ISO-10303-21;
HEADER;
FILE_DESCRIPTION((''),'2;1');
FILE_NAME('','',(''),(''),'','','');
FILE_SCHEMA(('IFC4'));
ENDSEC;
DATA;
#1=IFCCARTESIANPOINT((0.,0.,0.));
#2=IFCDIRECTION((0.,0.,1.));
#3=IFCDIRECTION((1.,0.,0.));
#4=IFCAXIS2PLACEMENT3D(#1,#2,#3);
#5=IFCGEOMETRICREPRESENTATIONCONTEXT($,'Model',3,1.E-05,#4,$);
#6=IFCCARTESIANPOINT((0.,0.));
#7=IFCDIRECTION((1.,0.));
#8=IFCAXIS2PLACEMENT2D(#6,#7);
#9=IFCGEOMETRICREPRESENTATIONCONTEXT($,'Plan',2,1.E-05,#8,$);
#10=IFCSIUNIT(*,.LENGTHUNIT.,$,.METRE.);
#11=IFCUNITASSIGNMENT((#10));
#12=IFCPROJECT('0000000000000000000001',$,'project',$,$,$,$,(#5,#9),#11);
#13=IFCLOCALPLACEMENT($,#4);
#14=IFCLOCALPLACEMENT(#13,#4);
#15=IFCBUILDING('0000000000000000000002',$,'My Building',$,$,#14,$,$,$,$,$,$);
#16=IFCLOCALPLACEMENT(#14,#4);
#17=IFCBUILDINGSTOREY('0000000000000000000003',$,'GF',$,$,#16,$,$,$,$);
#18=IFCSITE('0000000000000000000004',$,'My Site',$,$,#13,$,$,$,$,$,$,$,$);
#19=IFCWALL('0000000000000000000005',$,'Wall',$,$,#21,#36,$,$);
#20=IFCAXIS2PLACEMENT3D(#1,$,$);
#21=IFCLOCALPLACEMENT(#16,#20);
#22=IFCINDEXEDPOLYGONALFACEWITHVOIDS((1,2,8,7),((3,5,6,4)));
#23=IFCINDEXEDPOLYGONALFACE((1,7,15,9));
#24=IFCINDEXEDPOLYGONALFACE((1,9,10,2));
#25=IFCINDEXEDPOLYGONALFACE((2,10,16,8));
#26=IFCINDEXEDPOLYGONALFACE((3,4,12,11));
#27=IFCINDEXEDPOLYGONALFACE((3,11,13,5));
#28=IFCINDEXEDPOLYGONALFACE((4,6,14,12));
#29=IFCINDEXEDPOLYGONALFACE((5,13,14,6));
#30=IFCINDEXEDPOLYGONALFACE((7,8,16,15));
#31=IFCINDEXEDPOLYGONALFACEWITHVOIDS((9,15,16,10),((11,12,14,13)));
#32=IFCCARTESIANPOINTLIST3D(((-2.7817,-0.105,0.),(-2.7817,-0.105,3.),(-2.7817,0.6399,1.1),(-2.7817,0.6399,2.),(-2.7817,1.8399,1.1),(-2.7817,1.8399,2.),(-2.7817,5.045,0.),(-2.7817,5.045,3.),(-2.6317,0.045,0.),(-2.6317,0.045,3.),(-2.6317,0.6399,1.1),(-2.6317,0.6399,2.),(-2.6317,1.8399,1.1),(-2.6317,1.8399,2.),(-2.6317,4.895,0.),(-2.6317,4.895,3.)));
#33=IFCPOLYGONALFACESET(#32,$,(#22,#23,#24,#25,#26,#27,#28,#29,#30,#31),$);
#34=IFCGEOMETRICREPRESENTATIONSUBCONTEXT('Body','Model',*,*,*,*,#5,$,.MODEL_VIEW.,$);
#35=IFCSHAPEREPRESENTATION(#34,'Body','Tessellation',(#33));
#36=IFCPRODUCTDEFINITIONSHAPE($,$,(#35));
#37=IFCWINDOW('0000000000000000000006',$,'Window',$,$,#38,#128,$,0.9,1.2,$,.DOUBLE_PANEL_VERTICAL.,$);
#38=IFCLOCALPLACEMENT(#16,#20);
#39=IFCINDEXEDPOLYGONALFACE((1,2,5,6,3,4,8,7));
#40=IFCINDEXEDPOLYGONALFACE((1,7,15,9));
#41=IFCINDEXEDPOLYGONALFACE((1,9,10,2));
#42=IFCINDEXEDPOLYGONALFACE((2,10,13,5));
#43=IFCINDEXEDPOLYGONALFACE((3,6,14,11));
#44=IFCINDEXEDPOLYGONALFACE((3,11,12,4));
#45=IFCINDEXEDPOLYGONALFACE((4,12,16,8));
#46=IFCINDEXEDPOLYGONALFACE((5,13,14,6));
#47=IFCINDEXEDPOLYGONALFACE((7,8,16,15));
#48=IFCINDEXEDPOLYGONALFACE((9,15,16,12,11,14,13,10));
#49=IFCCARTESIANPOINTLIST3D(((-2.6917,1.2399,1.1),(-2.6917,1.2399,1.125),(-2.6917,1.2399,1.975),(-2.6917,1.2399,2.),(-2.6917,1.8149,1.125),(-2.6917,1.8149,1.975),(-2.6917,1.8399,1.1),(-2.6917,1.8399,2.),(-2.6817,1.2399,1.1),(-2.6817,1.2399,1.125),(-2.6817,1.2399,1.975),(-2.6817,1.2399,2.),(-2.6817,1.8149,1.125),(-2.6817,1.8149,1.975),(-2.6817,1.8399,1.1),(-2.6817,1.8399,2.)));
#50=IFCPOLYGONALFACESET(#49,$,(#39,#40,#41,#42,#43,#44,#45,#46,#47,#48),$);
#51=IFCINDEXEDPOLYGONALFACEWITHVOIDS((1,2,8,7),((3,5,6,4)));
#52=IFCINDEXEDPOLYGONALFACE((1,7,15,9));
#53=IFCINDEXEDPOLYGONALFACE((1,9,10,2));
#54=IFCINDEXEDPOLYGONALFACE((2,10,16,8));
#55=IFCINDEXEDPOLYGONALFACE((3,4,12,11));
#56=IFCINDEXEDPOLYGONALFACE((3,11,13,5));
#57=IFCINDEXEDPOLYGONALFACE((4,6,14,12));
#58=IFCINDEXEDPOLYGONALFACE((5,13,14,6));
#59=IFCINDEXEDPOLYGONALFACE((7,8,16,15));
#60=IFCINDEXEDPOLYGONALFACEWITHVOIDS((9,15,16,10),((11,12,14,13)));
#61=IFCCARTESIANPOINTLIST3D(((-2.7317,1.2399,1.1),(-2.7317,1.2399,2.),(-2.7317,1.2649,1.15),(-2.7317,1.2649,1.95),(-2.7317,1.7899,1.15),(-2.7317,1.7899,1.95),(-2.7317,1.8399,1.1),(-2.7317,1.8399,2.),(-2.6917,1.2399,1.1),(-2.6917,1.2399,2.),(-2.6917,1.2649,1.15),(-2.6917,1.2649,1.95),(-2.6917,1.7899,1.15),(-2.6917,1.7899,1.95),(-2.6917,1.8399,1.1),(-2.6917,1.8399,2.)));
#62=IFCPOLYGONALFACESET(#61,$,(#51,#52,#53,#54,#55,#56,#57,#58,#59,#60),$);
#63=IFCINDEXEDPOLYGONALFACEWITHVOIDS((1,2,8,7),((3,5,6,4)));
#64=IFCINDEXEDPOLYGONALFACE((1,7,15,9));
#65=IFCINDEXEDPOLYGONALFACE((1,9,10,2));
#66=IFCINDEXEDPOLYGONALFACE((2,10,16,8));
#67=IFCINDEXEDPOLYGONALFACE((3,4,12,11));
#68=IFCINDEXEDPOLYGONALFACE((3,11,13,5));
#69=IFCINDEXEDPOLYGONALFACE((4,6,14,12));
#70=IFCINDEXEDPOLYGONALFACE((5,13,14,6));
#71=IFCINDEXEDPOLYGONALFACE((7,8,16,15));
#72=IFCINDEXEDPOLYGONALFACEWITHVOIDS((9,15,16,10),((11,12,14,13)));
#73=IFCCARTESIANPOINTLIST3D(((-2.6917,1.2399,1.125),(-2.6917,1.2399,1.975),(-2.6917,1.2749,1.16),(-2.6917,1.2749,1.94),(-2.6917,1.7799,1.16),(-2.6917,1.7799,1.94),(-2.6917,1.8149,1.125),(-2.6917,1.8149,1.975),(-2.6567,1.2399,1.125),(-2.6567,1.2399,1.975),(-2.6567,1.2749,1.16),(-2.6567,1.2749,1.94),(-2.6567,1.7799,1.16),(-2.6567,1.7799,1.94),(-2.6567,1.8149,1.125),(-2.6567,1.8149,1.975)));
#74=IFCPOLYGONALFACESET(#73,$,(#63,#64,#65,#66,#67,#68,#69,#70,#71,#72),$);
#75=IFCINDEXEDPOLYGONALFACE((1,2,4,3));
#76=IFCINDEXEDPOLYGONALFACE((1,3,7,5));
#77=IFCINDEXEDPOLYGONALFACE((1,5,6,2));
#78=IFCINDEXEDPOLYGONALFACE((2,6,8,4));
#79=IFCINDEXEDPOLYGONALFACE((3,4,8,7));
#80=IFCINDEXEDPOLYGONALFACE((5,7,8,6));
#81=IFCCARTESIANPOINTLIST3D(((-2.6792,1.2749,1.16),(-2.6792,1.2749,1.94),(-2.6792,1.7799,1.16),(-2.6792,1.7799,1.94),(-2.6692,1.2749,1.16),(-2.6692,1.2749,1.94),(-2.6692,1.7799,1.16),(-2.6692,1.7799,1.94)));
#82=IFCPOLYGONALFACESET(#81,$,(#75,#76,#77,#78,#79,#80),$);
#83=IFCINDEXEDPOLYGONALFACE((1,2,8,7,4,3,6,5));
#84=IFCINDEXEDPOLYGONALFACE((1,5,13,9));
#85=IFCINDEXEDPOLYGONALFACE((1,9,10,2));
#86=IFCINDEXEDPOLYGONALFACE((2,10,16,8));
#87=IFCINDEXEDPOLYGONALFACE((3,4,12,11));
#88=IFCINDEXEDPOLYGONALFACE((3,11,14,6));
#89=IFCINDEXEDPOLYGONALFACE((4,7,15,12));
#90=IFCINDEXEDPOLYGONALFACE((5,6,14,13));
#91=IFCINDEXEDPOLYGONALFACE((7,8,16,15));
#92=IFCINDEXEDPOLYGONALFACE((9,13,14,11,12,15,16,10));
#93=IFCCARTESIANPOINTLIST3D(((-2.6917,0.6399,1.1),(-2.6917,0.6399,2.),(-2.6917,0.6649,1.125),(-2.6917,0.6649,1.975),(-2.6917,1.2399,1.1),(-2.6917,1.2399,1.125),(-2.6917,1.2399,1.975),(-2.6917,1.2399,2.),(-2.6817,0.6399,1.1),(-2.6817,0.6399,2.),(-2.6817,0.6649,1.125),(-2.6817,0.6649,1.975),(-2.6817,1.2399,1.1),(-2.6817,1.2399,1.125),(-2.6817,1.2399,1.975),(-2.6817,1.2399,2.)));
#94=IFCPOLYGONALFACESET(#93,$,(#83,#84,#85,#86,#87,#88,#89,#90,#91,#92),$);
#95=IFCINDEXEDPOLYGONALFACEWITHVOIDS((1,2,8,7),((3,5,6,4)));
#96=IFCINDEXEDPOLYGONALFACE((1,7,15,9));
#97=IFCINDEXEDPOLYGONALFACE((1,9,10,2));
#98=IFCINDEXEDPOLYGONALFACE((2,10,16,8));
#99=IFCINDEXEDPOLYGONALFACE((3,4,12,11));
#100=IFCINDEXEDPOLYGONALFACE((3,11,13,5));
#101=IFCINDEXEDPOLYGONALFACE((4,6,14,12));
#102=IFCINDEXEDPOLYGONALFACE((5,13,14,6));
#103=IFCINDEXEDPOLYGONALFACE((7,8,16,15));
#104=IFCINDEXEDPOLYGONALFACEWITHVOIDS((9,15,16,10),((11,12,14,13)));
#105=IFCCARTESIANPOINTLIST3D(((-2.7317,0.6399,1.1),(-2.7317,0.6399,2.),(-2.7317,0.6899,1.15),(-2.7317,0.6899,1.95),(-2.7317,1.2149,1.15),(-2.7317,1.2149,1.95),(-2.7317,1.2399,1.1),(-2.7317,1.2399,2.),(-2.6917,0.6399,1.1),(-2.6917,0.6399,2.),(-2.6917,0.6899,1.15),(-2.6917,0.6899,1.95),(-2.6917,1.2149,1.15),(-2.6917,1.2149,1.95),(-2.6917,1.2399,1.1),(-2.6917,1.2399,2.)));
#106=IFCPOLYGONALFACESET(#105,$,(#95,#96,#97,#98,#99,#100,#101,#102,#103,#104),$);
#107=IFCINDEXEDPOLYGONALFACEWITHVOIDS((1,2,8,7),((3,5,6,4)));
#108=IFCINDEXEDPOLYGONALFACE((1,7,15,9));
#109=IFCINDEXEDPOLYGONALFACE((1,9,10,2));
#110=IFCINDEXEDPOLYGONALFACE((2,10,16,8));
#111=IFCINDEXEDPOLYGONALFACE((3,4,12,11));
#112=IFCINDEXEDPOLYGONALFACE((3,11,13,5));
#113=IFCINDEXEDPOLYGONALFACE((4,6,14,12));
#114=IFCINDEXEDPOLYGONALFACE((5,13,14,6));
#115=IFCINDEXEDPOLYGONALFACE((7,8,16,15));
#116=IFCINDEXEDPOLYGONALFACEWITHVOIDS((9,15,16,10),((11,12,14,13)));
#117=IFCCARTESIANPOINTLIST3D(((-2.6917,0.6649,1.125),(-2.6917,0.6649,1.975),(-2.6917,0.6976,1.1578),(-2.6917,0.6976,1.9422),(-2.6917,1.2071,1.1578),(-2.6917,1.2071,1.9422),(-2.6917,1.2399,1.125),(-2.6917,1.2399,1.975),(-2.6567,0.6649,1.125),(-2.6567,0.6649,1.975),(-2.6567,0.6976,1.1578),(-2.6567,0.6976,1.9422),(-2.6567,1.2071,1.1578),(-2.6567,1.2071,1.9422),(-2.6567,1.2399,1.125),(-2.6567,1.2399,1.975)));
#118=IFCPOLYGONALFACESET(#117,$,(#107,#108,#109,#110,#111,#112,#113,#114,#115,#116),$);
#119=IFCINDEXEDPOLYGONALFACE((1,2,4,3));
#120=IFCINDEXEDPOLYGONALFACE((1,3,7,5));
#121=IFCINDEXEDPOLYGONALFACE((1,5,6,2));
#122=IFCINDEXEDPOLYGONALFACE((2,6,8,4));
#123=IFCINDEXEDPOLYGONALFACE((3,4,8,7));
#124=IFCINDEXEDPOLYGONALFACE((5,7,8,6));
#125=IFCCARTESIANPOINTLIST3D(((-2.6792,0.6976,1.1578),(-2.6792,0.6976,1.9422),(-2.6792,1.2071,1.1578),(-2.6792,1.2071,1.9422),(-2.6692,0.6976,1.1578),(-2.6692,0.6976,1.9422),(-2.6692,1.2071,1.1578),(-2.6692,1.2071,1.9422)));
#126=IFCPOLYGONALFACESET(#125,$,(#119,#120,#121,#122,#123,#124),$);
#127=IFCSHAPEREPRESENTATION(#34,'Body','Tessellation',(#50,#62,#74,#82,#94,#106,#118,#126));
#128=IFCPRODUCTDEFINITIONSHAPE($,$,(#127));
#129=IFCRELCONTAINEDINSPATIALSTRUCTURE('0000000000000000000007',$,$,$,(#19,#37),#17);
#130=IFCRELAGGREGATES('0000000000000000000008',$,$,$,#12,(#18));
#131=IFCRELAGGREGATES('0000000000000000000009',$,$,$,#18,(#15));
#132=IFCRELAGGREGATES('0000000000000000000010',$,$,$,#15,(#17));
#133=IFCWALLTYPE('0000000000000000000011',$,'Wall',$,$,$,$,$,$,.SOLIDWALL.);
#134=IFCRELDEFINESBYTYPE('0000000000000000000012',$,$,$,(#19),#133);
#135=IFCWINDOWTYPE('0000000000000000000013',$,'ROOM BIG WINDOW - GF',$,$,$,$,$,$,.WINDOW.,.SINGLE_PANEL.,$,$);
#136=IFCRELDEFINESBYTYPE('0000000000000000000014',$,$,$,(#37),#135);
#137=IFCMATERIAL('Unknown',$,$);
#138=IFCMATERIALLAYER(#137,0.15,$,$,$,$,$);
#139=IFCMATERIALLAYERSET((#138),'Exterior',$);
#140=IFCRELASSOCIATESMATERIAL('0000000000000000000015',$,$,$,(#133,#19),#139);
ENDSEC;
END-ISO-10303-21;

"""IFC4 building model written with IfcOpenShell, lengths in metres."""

from ifc_helpers import new_model, entity, si_unit, frame, origin_with_axes, origin_2d_with_axis, place, context, subcontext, project, spatial, line, indexed_curve, outline, extrude, shape, source, transform, mapped, material, layer, layer_set, layer_usage, type_object, type_shapes, element, fill, save


model = new_model("IFC4")

# Units and contexts
model_context = context("Model", 3, precision=1e-05, world=origin_with_axes())
plan_context = context("Plan", 2, precision=1e-05, world=origin_2d_with_axis())
body_context_1 = subcontext(model_context, "Body", "Model", "MODEL_VIEW")
body_context_2 = subcontext(plan_context, "Body", "Plan", "PLAN_VIEW")
ifc_project = project(units=[si_unit("LENGTHUNIT", "METRE")], contexts=[model_context, plan_context])

# Site, building, storey
site_placement = place(None, origin_with_axes())
site = spatial("IfcSite", under=ifc_project, at=site_placement, Name="My Site")
building_placement = place(site_placement, origin_with_axes())
building = spatial("IfcBuilding", under=site, at=building_placement, Name="My Building")
storey_placement = place(building_placement, origin_with_axes())
storey = spatial("IfcBuildingStorey", under=building, at=storey_placement, Name="GF")

# Shared definitions
ifc_material = material(Name="Unknown")

# Shared definitions
ifc_layer_1 = layer(ifc_material, 0.15)
ifc_layer_set_1 = layer_set([ifc_layer_1], Name="Exterior")
wall_type_1 = type_object("IfcWallType", Name="Wall", PredefinedType="SOLIDWALL", material=ifc_layer_set_1)

# Wall, opening, window
ifc_layer_usage_1 = layer_usage(ifc_layer_set_1, "AXIS2", "POSITIVE", 0.0)
wall_1_placement = place(storey_placement, frame((-2.7817, 5.045, 0.0), z_axis=(0.0, 0.0, 1.0), x_axis=(0.0, -1.0, 0.0)))
wall_1 = element("IfcWall", 1, at=wall_1_placement, inside=storey, type_object=wall_type_1, material=ifc_layer_usage_1, Name="Wall", context=body_context_1, shape_type="SweptSolid", body=[
    extrude(outline(indexed_curve([(0.0, 0.0), (0.15, 0.15), (5.0, 0.15), (5.15, 0.0)], segments=[line(1, 2, 3, 4, 1)])), origin_with_axes(), (0.0, 0.0, 1.0), 3.0),
])
shared_shape_1 = source(origin_with_axes(), body_context_1, "Body", "SweptSolid", [
    extrude(outline(indexed_curve([(0.0, 0.0), (1.2, 0.0), (1.2, 0.9), (0.0, 0.9)], segments=[line(1, 2, 3, 4, 1)])), frame((0.0, -0.6, 0.0), z_axis=(0.0, -1.0, 0.0), x_axis=(1.0, 0.0, 0.0)), (0.0, 0.0, -1.0), 1.2),
])
opening_1_placement = place(wall_1_placement, frame((3.2051, 0.0, 1.1), z_axis=(0.0, 0.0, 1.0), x_axis=(1.0, 0.0, 0.0)))
opening_1 = element("IfcOpeningElement", 2, at=opening_1_placement, cuts=wall_1, PredefinedType="OPENING", context=body_context_1, shape_type="MappedRepresentation", body=[
    mapped(shared_shape_1, transform((0.0, 0.0, 0.0), x_axis=(1.0, 0.0, 0.0), y_axis=(0.0, 1.0, 0.0), z_axis=(0.0, 0.0, 1.0), scale=1.0)),
])
window_type_1 = type_object("IfcWindowType", Name="ROOM BIG WINDOW - GF", PartitioningType="SINGLE_PANEL", PredefinedType="WINDOW")
shared_shape_2 = source(origin_with_axes(), body_context_1, "Body", "SweptSolid", [
    extrude(outline(indexed_curve([(0.6, 0.0), (0.0, 0.0), (0.0, 0.9), (0.6, 0.9), (0.6, 0.875), (0.025, 0.875), (0.025, 0.025), (0.6, 0.025)], segments=[line(1, 2, 3, 4, 5, 6, 7, 8, 1)])), frame((0.0, 0.09, 0.0), z_axis=(0.0, -1.0, 0.0), x_axis=(1.0, 0.0, 0.0)), (0.0, 0.0, -1.0), 0.01),
    extrude(outline(indexed_curve([(0.0, 0.0), (0.6, 0.0), (0.6, 0.9), (0.0, 0.9)], segments=[line(1, 2, 3, 4, 1)]), holes=[indexed_curve([(0.05, 0.05), (0.575, 0.05), (0.575, 0.85), (0.05, 0.85)], segments=[line(1, 2, 3, 4, 1)])]), frame((0.0, 0.05, 0.0), z_axis=(0.0, -1.0, 0.0), x_axis=(1.0, 0.0, 0.0)), (0.0, 0.0, -1.0), 0.04),
    extrude(outline(indexed_curve([(0.0, 0.0), (0.575, 0.0), (0.575, 0.85), (0.0, 0.85)], segments=[line(1, 2, 3, 4, 1)]), holes=[indexed_curve([(0.035, 0.035), (0.54, 0.035), (0.54, 0.815), (0.035, 0.815)], segments=[line(1, 2, 3, 4, 1)])]), frame((0.025, 0.09, 0.025), z_axis=(0.0, -1.0, 0.0), x_axis=(1.0, 0.0, 0.0)), (0.0, 0.0, -1.0), 0.035),
    extrude(outline(indexed_curve([(0.035, 0.035), (0.54, 0.035), (0.54, 0.815), (0.035, 0.815)], segments=[line(1, 2, 3, 4, 1)])), frame((0.025, 0.1025, 0.025), z_axis=(0.0, -1.0, 0.0), x_axis=(1.0, 0.0, 0.0)), (0.0, 0.0, -1.0), 0.01),
    extrude(outline(indexed_curve([(0.0, 0.9), (0.6, 0.9), (0.6, 0.0), (0.0, 0.0), (0.0, 0.025), (0.575, 0.025), (0.575, 0.875), (0.0, 0.875)], segments=[line(1, 2, 3, 4, 5, 6, 7, 8, 1)])), frame((0.6, 0.09, 0.0), z_axis=(0.0, -1.0, 0.0), x_axis=(1.0, 0.0, 0.0)), (0.0, 0.0, -1.0), 0.01),
    extrude(outline(indexed_curve([(0.0, 0.0), (0.6, 0.0), (0.6, 0.9), (0.0, 0.9)], segments=[line(1, 2, 3, 4, 1)]), holes=[indexed_curve([(0.025, 0.05), (0.55, 0.05), (0.55, 0.85), (0.025, 0.85)], segments=[line(1, 2, 3, 4, 1)])]), frame((0.6, 0.05, 0.0), z_axis=(0.0, -1.0, 0.0), x_axis=(1.0, 0.0, 0.0)), (0.0, 0.0, -1.0), 0.04),
    extrude(outline(indexed_curve([(0.0, 0.0), (0.575, 0.0), (0.575, 0.85), (0.0, 0.85)], segments=[line(1, 2, 3, 4, 1)]), holes=[indexed_curve([(0.0328, 0.0328), (0.5422, 0.0328), (0.5422, 0.8172), (0.0328, 0.8172)], segments=[line(1, 2, 3, 4, 1)])]), frame((0.6, 0.09, 0.025), z_axis=(0.0, -1.0, 0.0), x_axis=(1.0, 0.0, 0.0)), (0.0, 0.0, -1.0), 0.035),
    extrude(outline(indexed_curve([(0.0328, 0.0328), (0.5422, 0.0328), (0.5422, 0.8172), (0.0328, 0.8172)], segments=[line(1, 2, 3, 4, 1)])), frame((0.6, 0.1025, 0.025), z_axis=(0.0, -1.0, 0.0), x_axis=(1.0, 0.0, 0.0)), (0.0, 0.0, -1.0), 0.01),
])
shared_shape_3 = source(origin_with_axes(), body_context_2, "Body", "Curve2D", [
    entity("IfcIndexedPolyCurve", entity("IfcCartesianPointList2D", [[0.05, 0.05], [0.575, 0.05]])),
    entity("IfcIndexedPolyCurve", entity("IfcCartesianPointList2D", [[0.0, 0.1], [0.025, 0.1], [0.025, 0.09], [0.05, 0.09], [0.05, 0.05], [0.0, 0.05]]), [entity("IfcLineIndex", [1, 2, 3, 4, 5, 6, 1])]),
    entity("IfcIndexedPolyCurve", entity("IfcCartesianPointList2D", [[0.6, 0.1], [0.6, 0.1], [0.6, 0.09], [0.575, 0.09], [0.575, 0.05], [0.6, 0.05]])),
    entity("IfcIndexedPolyCurve", entity("IfcCartesianPointList2D", [[0.025, 0.09], [0.06, 0.09], [0.06, 0.125], [0.025, 0.125]]), [entity("IfcLineIndex", [1, 2, 3, 4, 1])]),
    entity("IfcIndexedPolyCurve", entity("IfcCartesianPointList2D", [[0.6, 0.09], [0.565, 0.09], [0.565, 0.125], [0.6, 0.125]]), [entity("IfcLineIndex", [1, 2, 3, 4, 1])]),
    entity("IfcIndexedPolyCurve", entity("IfcCartesianPointList2D", [[0.06, 0.09], [0.565, 0.09]])),
    entity("IfcIndexedPolyCurve", entity("IfcCartesianPointList2D", [[0.06, 0.125], [0.565, 0.125]])),
    entity("IfcIndexedPolyCurve", entity("IfcCartesianPointList2D", [[0.06, 0.1075], [0.565, 0.1075]])),
    entity("IfcIndexedPolyCurve", entity("IfcCartesianPointList2D", [[0.625, 0.05], [1.15, 0.05]])),
    entity("IfcIndexedPolyCurve", entity("IfcCartesianPointList2D", [[0.6, 0.1], [0.6, 0.1], [0.6, 0.09], [0.625, 0.09], [0.625, 0.05], [0.6, 0.05]])),
    entity("IfcIndexedPolyCurve", entity("IfcCartesianPointList2D", [[1.2, 0.1], [1.175, 0.1], [1.175, 0.09], [1.15, 0.09], [1.15, 0.05], [1.2, 0.05]]), [entity("IfcLineIndex", [1, 2, 3, 4, 5, 6, 1])]),
    entity("IfcIndexedPolyCurve", entity("IfcCartesianPointList2D", [[0.6, 0.09], [0.6328, 0.09], [0.6328, 0.125], [0.6, 0.125]]), [entity("IfcLineIndex", [1, 2, 3, 4, 1])]),
    entity("IfcIndexedPolyCurve", entity("IfcCartesianPointList2D", [[1.175, 0.09], [1.1422, 0.09], [1.1422, 0.125], [1.175, 0.125]]), [entity("IfcLineIndex", [1, 2, 3, 4, 1])]),
    entity("IfcIndexedPolyCurve", entity("IfcCartesianPointList2D", [[0.6328, 0.09], [1.1422, 0.09]])),
    entity("IfcIndexedPolyCurve", entity("IfcCartesianPointList2D", [[0.6328, 0.125], [1.1422, 0.125]])),
    entity("IfcIndexedPolyCurve", entity("IfcCartesianPointList2D", [[0.6328, 0.1075], [1.1422, 0.1075]])),
])
type_shapes(window_type_1, [shared_shape_2, shared_shape_3])
window_1_placement = place(opening_1_placement, frame((0.0, 0.0, 0.0), z_axis=(0.0, 0.0, 1.0), x_axis=(1.0, 0.0, 0.0)))
window_1 = element("IfcWindow", 3, at=window_1_placement, inside=storey, type_object=window_type_1, Name="Window", OverallHeight=0.9, OverallWidth=1.2, PartitioningType="DOUBLE_PANEL_VERTICAL", shapes=[
    shape(body_context_1, "Body", "MappedRepresentation", [mapped(shared_shape_2, transform((0.0, 0.0, 0.0), x_axis=(1.0, 0.0, 0.0), y_axis=(0.0, 1.0, 0.0), z_axis=(0.0, 0.0, 1.0), scale=1.0))]),
    shape(body_context_2, "Body", "MappedRepresentation", [mapped(shared_shape_3, transform((0.0, 0.0, 0.0), x_axis=(1.0, 0.0, 0.0), y_axis=(0.0, 1.0, 0.0), z_axis=(0.0, 0.0, 1.0), scale=1.0))]),
])
fill(opening_1, window_1)

save(model, "model.ifc")
